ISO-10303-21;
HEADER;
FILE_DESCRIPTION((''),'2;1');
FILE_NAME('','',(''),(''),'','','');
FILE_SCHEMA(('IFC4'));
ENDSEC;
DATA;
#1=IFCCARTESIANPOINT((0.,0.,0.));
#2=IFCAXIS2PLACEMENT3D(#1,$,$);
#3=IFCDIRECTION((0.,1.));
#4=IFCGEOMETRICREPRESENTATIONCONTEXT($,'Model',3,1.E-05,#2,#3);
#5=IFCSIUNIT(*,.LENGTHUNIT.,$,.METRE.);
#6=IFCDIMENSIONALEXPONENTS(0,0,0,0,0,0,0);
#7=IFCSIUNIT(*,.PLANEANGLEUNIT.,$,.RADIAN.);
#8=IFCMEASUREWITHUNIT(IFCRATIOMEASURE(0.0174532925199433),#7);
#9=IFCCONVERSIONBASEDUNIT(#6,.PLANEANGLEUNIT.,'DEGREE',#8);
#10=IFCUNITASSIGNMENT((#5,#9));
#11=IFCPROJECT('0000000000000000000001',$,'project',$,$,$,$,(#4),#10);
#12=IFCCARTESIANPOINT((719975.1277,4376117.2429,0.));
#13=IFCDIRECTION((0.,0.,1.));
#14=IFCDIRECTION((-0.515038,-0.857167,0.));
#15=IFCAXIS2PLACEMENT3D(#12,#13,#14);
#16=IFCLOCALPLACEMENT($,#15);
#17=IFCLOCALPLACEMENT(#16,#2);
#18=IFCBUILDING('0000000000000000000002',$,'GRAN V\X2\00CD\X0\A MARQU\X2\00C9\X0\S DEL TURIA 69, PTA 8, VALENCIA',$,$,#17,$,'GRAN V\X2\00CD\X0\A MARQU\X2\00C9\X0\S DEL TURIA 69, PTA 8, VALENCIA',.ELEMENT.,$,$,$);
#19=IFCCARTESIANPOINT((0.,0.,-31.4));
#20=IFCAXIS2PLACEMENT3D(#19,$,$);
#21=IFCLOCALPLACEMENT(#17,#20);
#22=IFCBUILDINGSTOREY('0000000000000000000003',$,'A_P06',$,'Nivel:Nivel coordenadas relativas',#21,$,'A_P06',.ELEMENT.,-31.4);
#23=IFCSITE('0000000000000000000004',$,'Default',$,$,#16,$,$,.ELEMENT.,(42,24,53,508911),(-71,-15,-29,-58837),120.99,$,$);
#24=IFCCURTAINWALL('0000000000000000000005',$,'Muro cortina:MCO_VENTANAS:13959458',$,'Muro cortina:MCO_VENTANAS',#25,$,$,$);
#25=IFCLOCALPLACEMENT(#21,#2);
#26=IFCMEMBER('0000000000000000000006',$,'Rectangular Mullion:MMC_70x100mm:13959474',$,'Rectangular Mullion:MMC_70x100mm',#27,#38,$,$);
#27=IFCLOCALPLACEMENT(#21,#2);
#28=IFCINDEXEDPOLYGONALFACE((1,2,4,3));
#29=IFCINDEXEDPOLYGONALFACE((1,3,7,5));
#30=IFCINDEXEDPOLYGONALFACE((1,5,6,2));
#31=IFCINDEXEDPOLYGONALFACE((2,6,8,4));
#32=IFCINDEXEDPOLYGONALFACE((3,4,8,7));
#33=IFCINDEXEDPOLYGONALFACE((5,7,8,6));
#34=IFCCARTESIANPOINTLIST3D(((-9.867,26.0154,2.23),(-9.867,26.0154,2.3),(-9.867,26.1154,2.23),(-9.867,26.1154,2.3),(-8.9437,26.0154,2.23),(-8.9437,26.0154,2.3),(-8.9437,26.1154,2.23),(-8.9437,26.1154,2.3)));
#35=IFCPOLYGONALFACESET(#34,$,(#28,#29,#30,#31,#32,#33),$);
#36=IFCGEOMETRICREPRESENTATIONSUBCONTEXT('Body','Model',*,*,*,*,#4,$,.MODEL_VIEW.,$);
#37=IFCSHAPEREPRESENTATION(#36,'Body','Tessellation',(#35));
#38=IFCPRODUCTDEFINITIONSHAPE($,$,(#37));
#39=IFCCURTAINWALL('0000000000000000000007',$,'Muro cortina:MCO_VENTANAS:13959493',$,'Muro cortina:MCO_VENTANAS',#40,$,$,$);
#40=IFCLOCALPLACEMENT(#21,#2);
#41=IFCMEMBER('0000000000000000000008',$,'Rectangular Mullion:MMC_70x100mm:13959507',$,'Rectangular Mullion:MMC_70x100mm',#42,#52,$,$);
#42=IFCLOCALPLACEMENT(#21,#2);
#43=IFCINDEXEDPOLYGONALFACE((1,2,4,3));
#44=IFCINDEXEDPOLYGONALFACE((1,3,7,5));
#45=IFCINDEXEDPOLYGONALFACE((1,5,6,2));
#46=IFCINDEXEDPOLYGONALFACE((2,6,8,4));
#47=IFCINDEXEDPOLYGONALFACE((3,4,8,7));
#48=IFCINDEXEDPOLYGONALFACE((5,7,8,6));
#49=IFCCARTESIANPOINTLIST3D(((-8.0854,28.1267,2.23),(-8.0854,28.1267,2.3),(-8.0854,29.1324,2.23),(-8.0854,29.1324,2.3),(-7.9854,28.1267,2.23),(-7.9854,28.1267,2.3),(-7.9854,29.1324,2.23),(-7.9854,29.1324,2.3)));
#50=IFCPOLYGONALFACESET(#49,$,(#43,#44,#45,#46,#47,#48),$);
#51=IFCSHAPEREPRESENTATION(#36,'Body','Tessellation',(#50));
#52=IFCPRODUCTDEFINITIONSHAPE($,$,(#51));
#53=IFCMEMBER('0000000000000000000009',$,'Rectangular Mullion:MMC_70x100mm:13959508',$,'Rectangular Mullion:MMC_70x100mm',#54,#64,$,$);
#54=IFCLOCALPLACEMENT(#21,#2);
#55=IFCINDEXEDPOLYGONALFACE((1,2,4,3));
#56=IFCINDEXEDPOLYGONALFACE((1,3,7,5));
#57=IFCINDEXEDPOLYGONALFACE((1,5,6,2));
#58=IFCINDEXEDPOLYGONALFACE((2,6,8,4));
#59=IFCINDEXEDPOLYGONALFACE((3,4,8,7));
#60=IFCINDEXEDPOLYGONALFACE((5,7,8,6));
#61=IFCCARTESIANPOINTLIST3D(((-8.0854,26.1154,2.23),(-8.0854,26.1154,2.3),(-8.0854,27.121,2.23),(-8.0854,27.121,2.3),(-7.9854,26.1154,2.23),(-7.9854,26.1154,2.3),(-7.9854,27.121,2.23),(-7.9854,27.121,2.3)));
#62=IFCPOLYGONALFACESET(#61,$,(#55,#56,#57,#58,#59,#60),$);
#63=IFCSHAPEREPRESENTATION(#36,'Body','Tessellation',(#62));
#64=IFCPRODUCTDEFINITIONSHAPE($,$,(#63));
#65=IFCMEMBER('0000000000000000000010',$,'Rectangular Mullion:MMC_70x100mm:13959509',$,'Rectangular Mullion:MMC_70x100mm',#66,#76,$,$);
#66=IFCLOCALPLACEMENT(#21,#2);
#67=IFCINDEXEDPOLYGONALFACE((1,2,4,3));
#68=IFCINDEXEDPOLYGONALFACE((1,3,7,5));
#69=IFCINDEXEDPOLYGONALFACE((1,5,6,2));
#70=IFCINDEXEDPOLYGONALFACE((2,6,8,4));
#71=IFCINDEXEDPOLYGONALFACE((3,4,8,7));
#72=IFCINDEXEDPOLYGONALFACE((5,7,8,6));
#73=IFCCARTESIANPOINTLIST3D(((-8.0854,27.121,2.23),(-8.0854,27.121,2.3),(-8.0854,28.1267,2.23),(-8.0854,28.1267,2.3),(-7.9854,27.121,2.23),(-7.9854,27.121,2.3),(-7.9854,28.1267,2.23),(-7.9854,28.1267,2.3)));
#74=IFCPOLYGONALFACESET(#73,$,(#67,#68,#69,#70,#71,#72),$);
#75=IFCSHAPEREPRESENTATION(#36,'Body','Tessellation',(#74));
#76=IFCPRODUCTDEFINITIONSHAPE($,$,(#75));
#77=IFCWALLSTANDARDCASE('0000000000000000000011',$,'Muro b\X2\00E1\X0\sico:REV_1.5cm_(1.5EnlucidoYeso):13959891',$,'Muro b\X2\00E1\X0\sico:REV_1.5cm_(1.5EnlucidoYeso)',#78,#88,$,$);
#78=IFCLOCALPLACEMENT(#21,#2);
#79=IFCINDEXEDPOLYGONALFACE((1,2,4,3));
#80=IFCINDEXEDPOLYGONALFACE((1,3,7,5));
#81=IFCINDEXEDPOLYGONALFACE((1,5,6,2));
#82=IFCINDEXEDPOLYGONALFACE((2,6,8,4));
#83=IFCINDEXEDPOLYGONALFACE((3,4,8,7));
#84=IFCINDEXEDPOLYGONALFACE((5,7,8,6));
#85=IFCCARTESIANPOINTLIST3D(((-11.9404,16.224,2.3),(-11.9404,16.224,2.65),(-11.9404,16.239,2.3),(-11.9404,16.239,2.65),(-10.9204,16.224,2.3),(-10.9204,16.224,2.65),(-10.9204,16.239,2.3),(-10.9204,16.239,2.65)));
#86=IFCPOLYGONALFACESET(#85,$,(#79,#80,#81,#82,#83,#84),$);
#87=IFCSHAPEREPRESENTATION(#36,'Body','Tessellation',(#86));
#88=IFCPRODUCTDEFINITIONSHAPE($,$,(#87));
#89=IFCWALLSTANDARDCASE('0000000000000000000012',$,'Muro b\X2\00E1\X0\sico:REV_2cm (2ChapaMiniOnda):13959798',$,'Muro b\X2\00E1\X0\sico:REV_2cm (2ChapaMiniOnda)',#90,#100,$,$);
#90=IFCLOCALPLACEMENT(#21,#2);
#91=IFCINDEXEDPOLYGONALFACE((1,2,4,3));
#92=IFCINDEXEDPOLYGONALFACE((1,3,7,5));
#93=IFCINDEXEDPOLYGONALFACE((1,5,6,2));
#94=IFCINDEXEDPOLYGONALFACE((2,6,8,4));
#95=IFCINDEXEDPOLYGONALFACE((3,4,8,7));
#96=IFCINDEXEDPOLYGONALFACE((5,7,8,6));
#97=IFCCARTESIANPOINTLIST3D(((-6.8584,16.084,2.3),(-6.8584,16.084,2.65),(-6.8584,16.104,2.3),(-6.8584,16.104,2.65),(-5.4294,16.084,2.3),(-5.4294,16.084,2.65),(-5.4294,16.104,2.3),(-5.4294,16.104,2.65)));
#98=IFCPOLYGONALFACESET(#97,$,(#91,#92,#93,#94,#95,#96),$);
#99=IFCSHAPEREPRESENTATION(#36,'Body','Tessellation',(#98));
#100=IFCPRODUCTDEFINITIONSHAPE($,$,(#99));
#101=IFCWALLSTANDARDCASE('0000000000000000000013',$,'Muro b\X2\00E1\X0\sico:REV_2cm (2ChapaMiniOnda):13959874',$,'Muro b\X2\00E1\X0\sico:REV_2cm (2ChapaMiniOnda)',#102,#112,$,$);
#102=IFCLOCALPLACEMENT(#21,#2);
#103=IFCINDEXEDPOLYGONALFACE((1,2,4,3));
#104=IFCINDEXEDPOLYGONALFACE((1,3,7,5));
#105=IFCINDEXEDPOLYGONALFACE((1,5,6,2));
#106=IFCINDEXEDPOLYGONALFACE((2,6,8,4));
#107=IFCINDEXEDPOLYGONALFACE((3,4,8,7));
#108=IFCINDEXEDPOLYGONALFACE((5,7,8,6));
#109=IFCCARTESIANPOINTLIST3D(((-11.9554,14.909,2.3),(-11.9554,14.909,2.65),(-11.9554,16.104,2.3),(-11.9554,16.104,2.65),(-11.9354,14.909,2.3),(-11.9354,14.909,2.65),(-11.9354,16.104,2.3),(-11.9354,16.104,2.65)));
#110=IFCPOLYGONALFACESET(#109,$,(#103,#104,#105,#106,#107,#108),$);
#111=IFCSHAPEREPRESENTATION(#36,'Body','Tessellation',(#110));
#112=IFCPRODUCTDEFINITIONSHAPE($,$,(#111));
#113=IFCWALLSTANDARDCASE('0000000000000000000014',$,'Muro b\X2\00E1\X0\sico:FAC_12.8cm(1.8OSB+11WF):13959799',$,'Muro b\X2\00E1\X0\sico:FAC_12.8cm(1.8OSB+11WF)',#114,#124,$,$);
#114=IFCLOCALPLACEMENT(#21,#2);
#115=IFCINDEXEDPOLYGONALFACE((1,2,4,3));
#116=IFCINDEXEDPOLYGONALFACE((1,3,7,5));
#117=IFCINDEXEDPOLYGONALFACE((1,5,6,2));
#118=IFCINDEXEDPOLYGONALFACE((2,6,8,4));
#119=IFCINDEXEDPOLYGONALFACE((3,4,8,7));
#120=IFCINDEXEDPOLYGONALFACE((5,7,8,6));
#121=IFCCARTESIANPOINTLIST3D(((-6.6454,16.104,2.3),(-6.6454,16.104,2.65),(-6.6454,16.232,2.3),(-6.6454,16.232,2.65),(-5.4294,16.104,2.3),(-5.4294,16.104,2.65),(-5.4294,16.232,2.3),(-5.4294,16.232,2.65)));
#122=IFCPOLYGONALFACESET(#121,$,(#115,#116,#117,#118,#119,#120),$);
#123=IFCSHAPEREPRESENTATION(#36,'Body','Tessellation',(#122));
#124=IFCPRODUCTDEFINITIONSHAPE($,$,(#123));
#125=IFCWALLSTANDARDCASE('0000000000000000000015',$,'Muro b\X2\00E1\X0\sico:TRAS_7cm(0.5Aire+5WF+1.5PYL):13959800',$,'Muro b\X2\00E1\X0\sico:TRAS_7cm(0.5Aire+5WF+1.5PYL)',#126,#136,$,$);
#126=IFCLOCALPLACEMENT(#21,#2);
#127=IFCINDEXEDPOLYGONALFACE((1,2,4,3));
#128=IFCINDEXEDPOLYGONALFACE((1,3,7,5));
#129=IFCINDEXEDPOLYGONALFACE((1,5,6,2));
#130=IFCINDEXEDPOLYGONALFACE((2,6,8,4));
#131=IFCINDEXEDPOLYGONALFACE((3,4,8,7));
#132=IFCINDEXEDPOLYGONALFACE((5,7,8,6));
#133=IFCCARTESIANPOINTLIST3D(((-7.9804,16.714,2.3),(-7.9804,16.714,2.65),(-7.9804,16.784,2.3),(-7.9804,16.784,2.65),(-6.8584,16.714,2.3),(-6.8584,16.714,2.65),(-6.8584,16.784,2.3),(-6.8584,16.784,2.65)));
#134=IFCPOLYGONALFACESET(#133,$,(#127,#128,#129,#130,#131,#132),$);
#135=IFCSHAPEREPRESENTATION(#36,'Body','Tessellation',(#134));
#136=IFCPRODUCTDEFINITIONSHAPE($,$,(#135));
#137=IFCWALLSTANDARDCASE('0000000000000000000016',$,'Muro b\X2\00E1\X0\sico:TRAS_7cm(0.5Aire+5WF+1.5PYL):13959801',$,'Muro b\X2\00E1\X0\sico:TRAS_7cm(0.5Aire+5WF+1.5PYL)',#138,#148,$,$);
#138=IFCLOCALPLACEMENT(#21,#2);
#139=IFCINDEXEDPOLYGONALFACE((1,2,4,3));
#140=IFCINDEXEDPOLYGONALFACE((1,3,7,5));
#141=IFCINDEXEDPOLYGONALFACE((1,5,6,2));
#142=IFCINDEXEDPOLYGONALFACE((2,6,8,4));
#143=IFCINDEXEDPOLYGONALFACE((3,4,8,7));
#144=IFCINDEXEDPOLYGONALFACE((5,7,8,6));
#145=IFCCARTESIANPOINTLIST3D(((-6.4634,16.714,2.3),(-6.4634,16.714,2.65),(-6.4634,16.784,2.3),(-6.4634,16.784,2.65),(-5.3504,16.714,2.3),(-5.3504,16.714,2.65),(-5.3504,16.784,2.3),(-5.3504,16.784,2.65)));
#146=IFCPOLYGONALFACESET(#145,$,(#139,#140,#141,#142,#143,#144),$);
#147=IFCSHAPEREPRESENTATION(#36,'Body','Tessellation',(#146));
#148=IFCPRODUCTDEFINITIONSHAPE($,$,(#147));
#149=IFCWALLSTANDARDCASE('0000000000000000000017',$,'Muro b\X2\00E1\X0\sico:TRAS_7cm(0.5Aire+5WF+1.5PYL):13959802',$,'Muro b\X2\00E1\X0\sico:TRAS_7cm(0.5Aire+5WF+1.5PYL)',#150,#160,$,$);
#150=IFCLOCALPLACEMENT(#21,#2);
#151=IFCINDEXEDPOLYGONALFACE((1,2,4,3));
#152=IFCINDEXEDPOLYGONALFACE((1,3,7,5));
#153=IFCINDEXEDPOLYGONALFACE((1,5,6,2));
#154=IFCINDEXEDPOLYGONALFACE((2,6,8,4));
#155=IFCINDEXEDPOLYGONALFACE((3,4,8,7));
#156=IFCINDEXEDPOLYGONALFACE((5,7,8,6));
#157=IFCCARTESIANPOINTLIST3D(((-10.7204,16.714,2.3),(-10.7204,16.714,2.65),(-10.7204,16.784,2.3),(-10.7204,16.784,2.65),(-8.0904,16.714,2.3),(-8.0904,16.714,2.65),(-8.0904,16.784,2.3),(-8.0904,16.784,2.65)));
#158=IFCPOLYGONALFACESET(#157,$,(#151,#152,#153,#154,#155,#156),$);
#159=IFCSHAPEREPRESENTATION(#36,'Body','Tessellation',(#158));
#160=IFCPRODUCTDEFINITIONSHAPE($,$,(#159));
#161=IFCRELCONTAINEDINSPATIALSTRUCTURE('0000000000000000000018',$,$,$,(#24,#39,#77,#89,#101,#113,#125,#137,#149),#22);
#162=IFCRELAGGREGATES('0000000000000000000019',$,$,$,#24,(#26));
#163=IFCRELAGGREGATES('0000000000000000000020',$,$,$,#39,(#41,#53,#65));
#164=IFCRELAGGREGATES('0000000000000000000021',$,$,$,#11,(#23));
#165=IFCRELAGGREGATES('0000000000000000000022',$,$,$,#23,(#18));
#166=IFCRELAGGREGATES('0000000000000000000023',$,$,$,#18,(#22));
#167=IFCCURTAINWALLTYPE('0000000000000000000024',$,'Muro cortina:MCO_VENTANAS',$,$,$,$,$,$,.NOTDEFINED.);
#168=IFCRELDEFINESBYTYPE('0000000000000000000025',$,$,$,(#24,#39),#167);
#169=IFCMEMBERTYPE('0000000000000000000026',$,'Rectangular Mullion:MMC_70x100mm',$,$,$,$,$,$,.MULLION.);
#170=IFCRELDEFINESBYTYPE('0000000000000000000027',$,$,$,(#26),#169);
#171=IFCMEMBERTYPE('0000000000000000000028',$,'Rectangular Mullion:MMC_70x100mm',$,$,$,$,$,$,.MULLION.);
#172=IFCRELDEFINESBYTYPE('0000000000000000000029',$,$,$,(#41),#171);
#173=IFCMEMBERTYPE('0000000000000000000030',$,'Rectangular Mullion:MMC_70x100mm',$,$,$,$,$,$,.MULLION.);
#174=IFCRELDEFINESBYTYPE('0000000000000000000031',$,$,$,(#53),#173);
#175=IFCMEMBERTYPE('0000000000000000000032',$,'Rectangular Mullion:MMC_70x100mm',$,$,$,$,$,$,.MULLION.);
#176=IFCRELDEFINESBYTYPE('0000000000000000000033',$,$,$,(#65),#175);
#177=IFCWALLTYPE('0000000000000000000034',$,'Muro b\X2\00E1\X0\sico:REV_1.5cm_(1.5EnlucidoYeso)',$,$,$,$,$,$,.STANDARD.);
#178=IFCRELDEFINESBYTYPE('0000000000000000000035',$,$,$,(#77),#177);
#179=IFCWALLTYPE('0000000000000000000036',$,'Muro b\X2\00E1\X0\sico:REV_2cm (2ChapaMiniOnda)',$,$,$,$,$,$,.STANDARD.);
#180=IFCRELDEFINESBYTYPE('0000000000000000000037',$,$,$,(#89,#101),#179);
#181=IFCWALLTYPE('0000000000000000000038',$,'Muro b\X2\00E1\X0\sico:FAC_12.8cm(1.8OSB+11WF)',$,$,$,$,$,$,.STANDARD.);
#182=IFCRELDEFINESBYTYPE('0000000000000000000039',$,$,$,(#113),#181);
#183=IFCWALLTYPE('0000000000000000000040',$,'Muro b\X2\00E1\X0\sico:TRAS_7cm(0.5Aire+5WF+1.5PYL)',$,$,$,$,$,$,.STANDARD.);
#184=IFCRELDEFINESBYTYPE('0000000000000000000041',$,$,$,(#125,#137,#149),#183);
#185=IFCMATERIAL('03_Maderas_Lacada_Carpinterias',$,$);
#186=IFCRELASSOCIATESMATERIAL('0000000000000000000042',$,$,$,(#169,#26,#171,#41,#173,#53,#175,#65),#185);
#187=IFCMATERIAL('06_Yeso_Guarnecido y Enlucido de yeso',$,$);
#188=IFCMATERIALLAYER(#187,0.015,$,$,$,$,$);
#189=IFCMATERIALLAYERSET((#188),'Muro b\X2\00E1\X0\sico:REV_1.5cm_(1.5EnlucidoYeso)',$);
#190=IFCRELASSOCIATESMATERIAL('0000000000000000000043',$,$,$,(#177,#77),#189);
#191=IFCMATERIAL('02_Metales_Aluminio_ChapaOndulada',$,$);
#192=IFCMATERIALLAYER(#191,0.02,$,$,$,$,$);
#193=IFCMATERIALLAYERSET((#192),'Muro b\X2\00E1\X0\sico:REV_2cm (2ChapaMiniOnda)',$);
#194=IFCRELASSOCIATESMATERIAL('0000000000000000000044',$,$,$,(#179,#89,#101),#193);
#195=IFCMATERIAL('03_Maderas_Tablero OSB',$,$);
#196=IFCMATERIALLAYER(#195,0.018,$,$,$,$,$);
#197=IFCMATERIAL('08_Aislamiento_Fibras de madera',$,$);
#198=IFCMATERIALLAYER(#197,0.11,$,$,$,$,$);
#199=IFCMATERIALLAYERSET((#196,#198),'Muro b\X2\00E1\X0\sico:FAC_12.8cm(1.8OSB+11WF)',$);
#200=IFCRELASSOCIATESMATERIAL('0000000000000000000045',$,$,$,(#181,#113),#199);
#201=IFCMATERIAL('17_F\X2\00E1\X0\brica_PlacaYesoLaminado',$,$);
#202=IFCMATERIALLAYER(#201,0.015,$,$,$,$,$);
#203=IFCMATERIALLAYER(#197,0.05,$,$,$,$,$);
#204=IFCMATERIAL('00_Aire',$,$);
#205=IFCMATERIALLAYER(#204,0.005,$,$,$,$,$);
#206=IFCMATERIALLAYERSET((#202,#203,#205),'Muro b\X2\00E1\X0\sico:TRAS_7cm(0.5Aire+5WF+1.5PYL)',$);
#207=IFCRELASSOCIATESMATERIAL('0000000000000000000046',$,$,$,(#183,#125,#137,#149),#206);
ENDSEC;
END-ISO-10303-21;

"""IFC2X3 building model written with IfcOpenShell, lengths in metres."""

from ifc_helpers import new_model, entity, si_unit, converted_unit, direction, frame, frame_2d, origin, origin_2d_with_axis, place, context, subcontext, project, spatial, rectangle, extrude, source, transform, mapped, material, layer, layer_set, layer_usage, type_object, type_shapes, element, aggregate, save


model = new_model("IFC2X3")

# Units and contexts
model_context = context("Model", 3, precision=1e-05, world=origin(), true_north=direction((0.0, 1.0)))
body_context = subcontext(model_context, "Body", "Model", "MODEL_VIEW")
ifc_project = project(units=[si_unit("LENGTHUNIT", "METRE"), converted_unit("PLANEANGLEUNIT", "DEGREE", entity("IfcRatioMeasure", 0.0174532925199433), si_unit("PLANEANGLEUNIT", "RADIAN"), dimensions=[0, 0, 0, 0, 0, 0, 0])], contexts=[model_context])

# Site, building, storey
site_placement = place(None, frame((719975.1277, 4376117.2429, 0.0), z_axis=(0.0, 0.0, 1.0), x_axis=(-0.515038, -0.857167, 0.0)))
site = spatial("IfcSite", under=ifc_project, at=site_placement, Name="Default", CompositionType="ELEMENT", RefLatitude=(42, 24, 53, 508911), RefLongitude=(-71, -15, -29, -58837), RefElevation=120.99)
building_placement = place(site_placement, origin())
building = spatial("IfcBuilding", under=site, at=building_placement, Name="GRAN VÍA MARQUÉS DEL TURIA 69, PTA 8, VALENCIA", LongName="GRAN VÍA MARQUÉS DEL TURIA 69, PTA 8, VALENCIA", CompositionType="ELEMENT")
storey_placement = place(building_placement, frame((0.0, 0.0, -31.4)))
storey = spatial("IfcBuildingStorey", under=building, at=storey_placement, Name="A_P06", ObjectType="Nivel:Nivel coordenadas relativas", LongName="A_P06", CompositionType="ELEMENT", Elevation=-31.4)

# Shared definitions
curtain_wall_type = type_object("IfcCurtainWallType", Name="Muro cortina:MCO_VENTANAS", PredefinedType="NOTDEFINED")
ifc_material_1 = material(Name="03_Maderas_Lacada_Carpinterias")

# Curtain walls, members
curtain_wall_1_placement = place(storey_placement, frame((0.0, 0.0, 31.4)))
curtain_wall_1 = element("IfcCurtainWall", 1, at=curtain_wall_1_placement, inside=storey, type_object=curtain_wall_type, Name="Muro cortina:MCO_VENTANAS:13959458", ObjectType="Muro cortina:MCO_VENTANAS")
member_type_1 = type_object("IfcMemberType", Name="Rectangular Mullion:MMC_70x100mm", PredefinedType="MULLION", material=ifc_material_1)
shared_shape_1 = source(origin(), body_context, "Body", "SweptSolid", [
    extrude(rectangle(XDim=0.1, YDim=0.07, at=origin_2d_with_axis()), frame((-0.035, 0.0, -0.9233), z_axis=(0.0, 0.0, 1.0), x_axis=(0.0, -1.0, 0.0)), (0.0, 0.0, 1.0), 0.9233),
])
type_shapes(member_type_1, [shared_shape_1])
member_1_placement = place(storey_placement, frame((-8.9437, 26.0654, 2.3), z_axis=(1.0, 0.0, 0.0), x_axis=(0.0, 0.0, 1.0)))
member_1 = element("IfcMember", 2, at=member_1_placement, type_object=member_type_1, material=ifc_material_1, Name="Rectangular Mullion:MMC_70x100mm:13959474", ObjectType="Rectangular Mullion:MMC_70x100mm", context=body_context, shape_type="MappedRepresentation", body=[
    mapped(shared_shape_1, transform((0.0, 0.0, 0.0), scale=1.0)),
])
aggregate(curtain_wall_1, [member_1])
curtain_wall_2_placement = place(storey_placement, frame((0.0, 0.0, 31.4)))
curtain_wall_2 = element("IfcCurtainWall", 3, at=curtain_wall_2_placement, inside=storey, type_object=curtain_wall_type, Name="Muro cortina:MCO_VENTANAS:13959493", ObjectType="Muro cortina:MCO_VENTANAS")
member_type_2 = type_object("IfcMemberType", Name="Rectangular Mullion:MMC_70x100mm", PredefinedType="MULLION", material=ifc_material_1)
shared_shape_2 = source(origin(), body_context, "Body", "SweptSolid", [
    extrude(rectangle(XDim=0.1, YDim=0.07, at=origin_2d_with_axis()), frame((-0.035, 0.0, -1.0057), z_axis=(0.0, 0.0, 1.0), x_axis=(0.0, -1.0, 0.0)), (0.0, 0.0, 1.0), 1.0057),
])
type_shapes(member_type_2, [shared_shape_2])
member_2_placement = place(storey_placement, frame((-8.0354, 29.1324, 2.3), z_axis=(0.0, 1.0, 0.0), x_axis=(0.0, 0.0, 1.0)))
member_2 = element("IfcMember", 4, at=member_2_placement, type_object=member_type_2, material=ifc_material_1, Name="Rectangular Mullion:MMC_70x100mm:13959507", ObjectType="Rectangular Mullion:MMC_70x100mm", context=body_context, shape_type="MappedRepresentation", body=[
    mapped(shared_shape_2, transform((0.0, 0.0, 0.0), scale=1.0)),
])
member_type_3 = type_object("IfcMemberType", Name="Rectangular Mullion:MMC_70x100mm", PredefinedType="MULLION", material=ifc_material_1)
shared_shape_3 = source(origin(), body_context, "Body", "SweptSolid", [
    extrude(rectangle(XDim=0.1, YDim=0.07, at=origin_2d_with_axis()), frame((-0.035, 0.0, -1.0057), z_axis=(0.0, 0.0, 1.0), x_axis=(0.0, -1.0, 0.0)), (0.0, 0.0, 1.0), 1.0057),
])
type_shapes(member_type_3, [shared_shape_3])
member_3_placement = place(storey_placement, frame((-8.0354, 27.121, 2.3), z_axis=(0.0, 1.0, 0.0), x_axis=(0.0, 0.0, 1.0)))
member_3 = element("IfcMember", 5, at=member_3_placement, type_object=member_type_3, material=ifc_material_1, Name="Rectangular Mullion:MMC_70x100mm:13959508", ObjectType="Rectangular Mullion:MMC_70x100mm", context=body_context, shape_type="MappedRepresentation", body=[
    mapped(shared_shape_3, transform((0.0, 0.0, 0.0), scale=1.0)),
])
member_type_4 = type_object("IfcMemberType", Name="Rectangular Mullion:MMC_70x100mm", PredefinedType="MULLION", material=ifc_material_1)
shared_shape_4 = source(origin(), body_context, "Body", "SweptSolid", [
    extrude(rectangle(XDim=0.1, YDim=0.07, at=origin_2d_with_axis()), frame((-0.035, 0.0, -1.0057), z_axis=(0.0, 0.0, 1.0), x_axis=(0.0, -1.0, 0.0)), (0.0, 0.0, 1.0), 1.0057),
])
type_shapes(member_type_4, [shared_shape_4])
member_4_placement = place(storey_placement, frame((-8.0354, 28.1267, 2.3), z_axis=(0.0, 1.0, 0.0), x_axis=(0.0, 0.0, 1.0)))
member_4 = element("IfcMember", 6, at=member_4_placement, type_object=member_type_4, material=ifc_material_1, Name="Rectangular Mullion:MMC_70x100mm:13959509", ObjectType="Rectangular Mullion:MMC_70x100mm", context=body_context, shape_type="MappedRepresentation", body=[
    mapped(shared_shape_4, transform((0.0, 0.0, 0.0), scale=1.0)),
])
aggregate(curtain_wall_2, [member_2, member_3, member_4])

# Walls
ifc_material_2 = material(Name="06_Yeso_Guarnecido y Enlucido de yeso")
ifc_layer_1 = layer(ifc_material_2, 0.015)
ifc_layer_set_1 = layer_set([ifc_layer_1], Name="Muro básico:REV_1.5cm_(1.5EnlucidoYeso)")
ifc_layer_usage_1 = layer_usage(ifc_layer_set_1, "AXIS2", "NEGATIVE", 0.0075)
wall_type_1 = type_object("IfcWallType", Name="Muro básico:REV_1.5cm_(1.5EnlucidoYeso)", PredefinedType="STANDARD", material=ifc_layer_set_1)
wall_1_placement = place(storey_placement, frame((-10.9204, 16.2315, 2.3), z_axis=(0.0, 0.0, 1.0), x_axis=(-1.0, 0.0, 0.0)))
element("IfcWallStandardCase", 7, at=wall_1_placement, inside=storey, type_object=wall_type_1, material=ifc_layer_usage_1, Name="Muro básico:REV_1.5cm_(1.5EnlucidoYeso):13959891", ObjectType="Muro básico:REV_1.5cm_(1.5EnlucidoYeso)", context=body_context, shape_type="SweptSolid", body=[
    extrude(rectangle(XDim=1.02, YDim=0.015, at=frame_2d((0.51, 0.0), x_axis=(-1.0, 0.0))), origin(), (0.0, 0.0, 1.0), 0.35),
])
ifc_material_3 = material(Name="02_Metales_Aluminio_ChapaOndulada")
ifc_layer_2 = layer(ifc_material_3, 0.02)
ifc_layer_set_2 = layer_set([ifc_layer_2], Name="Muro básico:REV_2cm (2ChapaMiniOnda)")
ifc_layer_usage_2 = layer_usage(ifc_layer_set_2, "AXIS2", "NEGATIVE", 0.01)
wall_type_2 = type_object("IfcWallType", Name="Muro básico:REV_2cm (2ChapaMiniOnda)", PredefinedType="STANDARD", material=ifc_layer_set_2)
wall_2_placement = place(storey_placement, frame((-6.8584, 16.094, 2.3)))
element("IfcWallStandardCase", 8, at=wall_2_placement, inside=storey, type_object=wall_type_2, material=ifc_layer_usage_2, Name="Muro básico:REV_2cm (2ChapaMiniOnda):13959798", ObjectType="Muro básico:REV_2cm (2ChapaMiniOnda)", context=body_context, shape_type="SweptSolid", body=[
    extrude(rectangle(XDim=1.429, YDim=0.02, at=frame_2d((0.7145, 0.0), x_axis=(-1.0, 0.0))), origin(), (0.0, 0.0, 1.0), 0.35),
])
ifc_layer_usage_3 = layer_usage(ifc_layer_set_2, "AXIS2", "NEGATIVE", 0.01)
wall_3_placement = place(storey_placement, frame((-11.9454, 16.104, 2.3), z_axis=(0.0, 0.0, 1.0), x_axis=(0.0, -1.0, 0.0)))
element("IfcWallStandardCase", 9, at=wall_3_placement, inside=storey, type_object=wall_type_2, material=ifc_layer_usage_3, Name="Muro básico:REV_2cm (2ChapaMiniOnda):13959874", ObjectType="Muro básico:REV_2cm (2ChapaMiniOnda)", context=body_context, shape_type="SweptSolid", body=[
    extrude(rectangle(XDim=1.195, YDim=0.02, at=frame_2d((0.5975, 0.0), x_axis=(-1.0, 0.0))), origin(), (0.0, 0.0, 1.0), 0.35),
])
ifc_material_4 = material(Name="03_Maderas_Tablero OSB")
ifc_layer_3 = layer(ifc_material_4, 0.018)
ifc_material_5 = material(Name="08_Aislamiento_Fibras de madera")
ifc_layer_4 = layer(ifc_material_5, 0.11)
ifc_layer_set_3 = layer_set([ifc_layer_3, ifc_layer_4], Name="Muro básico:FAC_12.8cm(1.8OSB+11WF)")
ifc_layer_usage_4 = layer_usage(ifc_layer_set_3, "AXIS2", "NEGATIVE", 0.064)
wall_type_3 = type_object("IfcWallType", Name="Muro básico:FAC_12.8cm(1.8OSB+11WF)", PredefinedType="STANDARD", material=ifc_layer_set_3)
wall_4_placement = place(storey_placement, frame((-5.4294, 16.168, 2.3), z_axis=(0.0, 0.0, 1.0), x_axis=(-1.0, 0.0, 0.0)))
element("IfcWallStandardCase", 10, at=wall_4_placement, inside=storey, type_object=wall_type_3, material=ifc_layer_usage_4, Name="Muro básico:FAC_12.8cm(1.8OSB+11WF):13959799", ObjectType="Muro básico:FAC_12.8cm(1.8OSB+11WF)", context=body_context, shape_type="SweptSolid", body=[
    extrude(rectangle(XDim=1.216, YDim=0.128, at=frame_2d((0.608, 0.0), x_axis=(-1.0, 0.0))), origin(), (0.0, 0.0, 1.0), 0.35),
])
ifc_material_6 = material(Name="17_Fábrica_PlacaYesoLaminado")
ifc_layer_5 = layer(ifc_material_6, 0.015)
ifc_layer_6 = layer(ifc_material_5, 0.05)
ifc_material_7 = material(Name="00_Aire")
ifc_layer_7 = layer(ifc_material_7, 0.005)
ifc_layer_set_4 = layer_set([ifc_layer_5, ifc_layer_6, ifc_layer_7], Name="Muro básico:TRAS_7cm(0.5Aire+5WF+1.5PYL)")
ifc_layer_usage_5 = layer_usage(ifc_layer_set_4, "AXIS2", "NEGATIVE", 0.035)
wall_type_4 = type_object("IfcWallType", Name="Muro básico:TRAS_7cm(0.5Aire+5WF+1.5PYL)", PredefinedType="STANDARD", material=ifc_layer_set_4)
wall_5_placement = place(storey_placement, frame((-7.9804, 16.749, 2.3)))
element("IfcWallStandardCase", 11, at=wall_5_placement, inside=storey, type_object=wall_type_4, material=ifc_layer_usage_5, Name="Muro básico:TRAS_7cm(0.5Aire+5WF+1.5PYL):13959800", ObjectType="Muro básico:TRAS_7cm(0.5Aire+5WF+1.5PYL)", context=body_context, shape_type="SweptSolid", body=[
    extrude(rectangle(XDim=1.122, YDim=0.07, at=frame_2d((0.561, 0.0), x_axis=(-1.0, 0.0))), origin(), (0.0, 0.0, 1.0), 0.35),
])
ifc_layer_usage_6 = layer_usage(ifc_layer_set_4, "AXIS2", "NEGATIVE", 0.035)
wall_6_placement = place(storey_placement, frame((-6.4634, 16.749, 2.3)))
element("IfcWallStandardCase", 12, at=wall_6_placement, inside=storey, type_object=wall_type_4, material=ifc_layer_usage_6, Name="Muro básico:TRAS_7cm(0.5Aire+5WF+1.5PYL):13959801", ObjectType="Muro básico:TRAS_7cm(0.5Aire+5WF+1.5PYL)", context=body_context, shape_type="SweptSolid", body=[
    extrude(rectangle(XDim=1.113, YDim=0.07, at=frame_2d((0.5565, 0.0), x_axis=(-1.0, 0.0))), origin(), (0.0, 0.0, 1.0), 0.35),
])
ifc_layer_usage_7 = layer_usage(ifc_layer_set_4, "AXIS2", "NEGATIVE", 0.035)
wall_7_placement = place(storey_placement, frame((-10.7204, 16.749, 2.3)))
element("IfcWallStandardCase", 13, at=wall_7_placement, inside=storey, type_object=wall_type_4, material=ifc_layer_usage_7, Name="Muro básico:TRAS_7cm(0.5Aire+5WF+1.5PYL):13959802", ObjectType="Muro básico:TRAS_7cm(0.5Aire+5WF+1.5PYL)", context=body_context, shape_type="SweptSolid", body=[
    extrude(rectangle(XDim=2.63, YDim=0.07, at=frame_2d((1.315, 0.0), x_axis=(-1.0, 0.0))), origin(), (0.0, 0.0, 1.0), 0.35),
])

save(model, "model.ifc")
